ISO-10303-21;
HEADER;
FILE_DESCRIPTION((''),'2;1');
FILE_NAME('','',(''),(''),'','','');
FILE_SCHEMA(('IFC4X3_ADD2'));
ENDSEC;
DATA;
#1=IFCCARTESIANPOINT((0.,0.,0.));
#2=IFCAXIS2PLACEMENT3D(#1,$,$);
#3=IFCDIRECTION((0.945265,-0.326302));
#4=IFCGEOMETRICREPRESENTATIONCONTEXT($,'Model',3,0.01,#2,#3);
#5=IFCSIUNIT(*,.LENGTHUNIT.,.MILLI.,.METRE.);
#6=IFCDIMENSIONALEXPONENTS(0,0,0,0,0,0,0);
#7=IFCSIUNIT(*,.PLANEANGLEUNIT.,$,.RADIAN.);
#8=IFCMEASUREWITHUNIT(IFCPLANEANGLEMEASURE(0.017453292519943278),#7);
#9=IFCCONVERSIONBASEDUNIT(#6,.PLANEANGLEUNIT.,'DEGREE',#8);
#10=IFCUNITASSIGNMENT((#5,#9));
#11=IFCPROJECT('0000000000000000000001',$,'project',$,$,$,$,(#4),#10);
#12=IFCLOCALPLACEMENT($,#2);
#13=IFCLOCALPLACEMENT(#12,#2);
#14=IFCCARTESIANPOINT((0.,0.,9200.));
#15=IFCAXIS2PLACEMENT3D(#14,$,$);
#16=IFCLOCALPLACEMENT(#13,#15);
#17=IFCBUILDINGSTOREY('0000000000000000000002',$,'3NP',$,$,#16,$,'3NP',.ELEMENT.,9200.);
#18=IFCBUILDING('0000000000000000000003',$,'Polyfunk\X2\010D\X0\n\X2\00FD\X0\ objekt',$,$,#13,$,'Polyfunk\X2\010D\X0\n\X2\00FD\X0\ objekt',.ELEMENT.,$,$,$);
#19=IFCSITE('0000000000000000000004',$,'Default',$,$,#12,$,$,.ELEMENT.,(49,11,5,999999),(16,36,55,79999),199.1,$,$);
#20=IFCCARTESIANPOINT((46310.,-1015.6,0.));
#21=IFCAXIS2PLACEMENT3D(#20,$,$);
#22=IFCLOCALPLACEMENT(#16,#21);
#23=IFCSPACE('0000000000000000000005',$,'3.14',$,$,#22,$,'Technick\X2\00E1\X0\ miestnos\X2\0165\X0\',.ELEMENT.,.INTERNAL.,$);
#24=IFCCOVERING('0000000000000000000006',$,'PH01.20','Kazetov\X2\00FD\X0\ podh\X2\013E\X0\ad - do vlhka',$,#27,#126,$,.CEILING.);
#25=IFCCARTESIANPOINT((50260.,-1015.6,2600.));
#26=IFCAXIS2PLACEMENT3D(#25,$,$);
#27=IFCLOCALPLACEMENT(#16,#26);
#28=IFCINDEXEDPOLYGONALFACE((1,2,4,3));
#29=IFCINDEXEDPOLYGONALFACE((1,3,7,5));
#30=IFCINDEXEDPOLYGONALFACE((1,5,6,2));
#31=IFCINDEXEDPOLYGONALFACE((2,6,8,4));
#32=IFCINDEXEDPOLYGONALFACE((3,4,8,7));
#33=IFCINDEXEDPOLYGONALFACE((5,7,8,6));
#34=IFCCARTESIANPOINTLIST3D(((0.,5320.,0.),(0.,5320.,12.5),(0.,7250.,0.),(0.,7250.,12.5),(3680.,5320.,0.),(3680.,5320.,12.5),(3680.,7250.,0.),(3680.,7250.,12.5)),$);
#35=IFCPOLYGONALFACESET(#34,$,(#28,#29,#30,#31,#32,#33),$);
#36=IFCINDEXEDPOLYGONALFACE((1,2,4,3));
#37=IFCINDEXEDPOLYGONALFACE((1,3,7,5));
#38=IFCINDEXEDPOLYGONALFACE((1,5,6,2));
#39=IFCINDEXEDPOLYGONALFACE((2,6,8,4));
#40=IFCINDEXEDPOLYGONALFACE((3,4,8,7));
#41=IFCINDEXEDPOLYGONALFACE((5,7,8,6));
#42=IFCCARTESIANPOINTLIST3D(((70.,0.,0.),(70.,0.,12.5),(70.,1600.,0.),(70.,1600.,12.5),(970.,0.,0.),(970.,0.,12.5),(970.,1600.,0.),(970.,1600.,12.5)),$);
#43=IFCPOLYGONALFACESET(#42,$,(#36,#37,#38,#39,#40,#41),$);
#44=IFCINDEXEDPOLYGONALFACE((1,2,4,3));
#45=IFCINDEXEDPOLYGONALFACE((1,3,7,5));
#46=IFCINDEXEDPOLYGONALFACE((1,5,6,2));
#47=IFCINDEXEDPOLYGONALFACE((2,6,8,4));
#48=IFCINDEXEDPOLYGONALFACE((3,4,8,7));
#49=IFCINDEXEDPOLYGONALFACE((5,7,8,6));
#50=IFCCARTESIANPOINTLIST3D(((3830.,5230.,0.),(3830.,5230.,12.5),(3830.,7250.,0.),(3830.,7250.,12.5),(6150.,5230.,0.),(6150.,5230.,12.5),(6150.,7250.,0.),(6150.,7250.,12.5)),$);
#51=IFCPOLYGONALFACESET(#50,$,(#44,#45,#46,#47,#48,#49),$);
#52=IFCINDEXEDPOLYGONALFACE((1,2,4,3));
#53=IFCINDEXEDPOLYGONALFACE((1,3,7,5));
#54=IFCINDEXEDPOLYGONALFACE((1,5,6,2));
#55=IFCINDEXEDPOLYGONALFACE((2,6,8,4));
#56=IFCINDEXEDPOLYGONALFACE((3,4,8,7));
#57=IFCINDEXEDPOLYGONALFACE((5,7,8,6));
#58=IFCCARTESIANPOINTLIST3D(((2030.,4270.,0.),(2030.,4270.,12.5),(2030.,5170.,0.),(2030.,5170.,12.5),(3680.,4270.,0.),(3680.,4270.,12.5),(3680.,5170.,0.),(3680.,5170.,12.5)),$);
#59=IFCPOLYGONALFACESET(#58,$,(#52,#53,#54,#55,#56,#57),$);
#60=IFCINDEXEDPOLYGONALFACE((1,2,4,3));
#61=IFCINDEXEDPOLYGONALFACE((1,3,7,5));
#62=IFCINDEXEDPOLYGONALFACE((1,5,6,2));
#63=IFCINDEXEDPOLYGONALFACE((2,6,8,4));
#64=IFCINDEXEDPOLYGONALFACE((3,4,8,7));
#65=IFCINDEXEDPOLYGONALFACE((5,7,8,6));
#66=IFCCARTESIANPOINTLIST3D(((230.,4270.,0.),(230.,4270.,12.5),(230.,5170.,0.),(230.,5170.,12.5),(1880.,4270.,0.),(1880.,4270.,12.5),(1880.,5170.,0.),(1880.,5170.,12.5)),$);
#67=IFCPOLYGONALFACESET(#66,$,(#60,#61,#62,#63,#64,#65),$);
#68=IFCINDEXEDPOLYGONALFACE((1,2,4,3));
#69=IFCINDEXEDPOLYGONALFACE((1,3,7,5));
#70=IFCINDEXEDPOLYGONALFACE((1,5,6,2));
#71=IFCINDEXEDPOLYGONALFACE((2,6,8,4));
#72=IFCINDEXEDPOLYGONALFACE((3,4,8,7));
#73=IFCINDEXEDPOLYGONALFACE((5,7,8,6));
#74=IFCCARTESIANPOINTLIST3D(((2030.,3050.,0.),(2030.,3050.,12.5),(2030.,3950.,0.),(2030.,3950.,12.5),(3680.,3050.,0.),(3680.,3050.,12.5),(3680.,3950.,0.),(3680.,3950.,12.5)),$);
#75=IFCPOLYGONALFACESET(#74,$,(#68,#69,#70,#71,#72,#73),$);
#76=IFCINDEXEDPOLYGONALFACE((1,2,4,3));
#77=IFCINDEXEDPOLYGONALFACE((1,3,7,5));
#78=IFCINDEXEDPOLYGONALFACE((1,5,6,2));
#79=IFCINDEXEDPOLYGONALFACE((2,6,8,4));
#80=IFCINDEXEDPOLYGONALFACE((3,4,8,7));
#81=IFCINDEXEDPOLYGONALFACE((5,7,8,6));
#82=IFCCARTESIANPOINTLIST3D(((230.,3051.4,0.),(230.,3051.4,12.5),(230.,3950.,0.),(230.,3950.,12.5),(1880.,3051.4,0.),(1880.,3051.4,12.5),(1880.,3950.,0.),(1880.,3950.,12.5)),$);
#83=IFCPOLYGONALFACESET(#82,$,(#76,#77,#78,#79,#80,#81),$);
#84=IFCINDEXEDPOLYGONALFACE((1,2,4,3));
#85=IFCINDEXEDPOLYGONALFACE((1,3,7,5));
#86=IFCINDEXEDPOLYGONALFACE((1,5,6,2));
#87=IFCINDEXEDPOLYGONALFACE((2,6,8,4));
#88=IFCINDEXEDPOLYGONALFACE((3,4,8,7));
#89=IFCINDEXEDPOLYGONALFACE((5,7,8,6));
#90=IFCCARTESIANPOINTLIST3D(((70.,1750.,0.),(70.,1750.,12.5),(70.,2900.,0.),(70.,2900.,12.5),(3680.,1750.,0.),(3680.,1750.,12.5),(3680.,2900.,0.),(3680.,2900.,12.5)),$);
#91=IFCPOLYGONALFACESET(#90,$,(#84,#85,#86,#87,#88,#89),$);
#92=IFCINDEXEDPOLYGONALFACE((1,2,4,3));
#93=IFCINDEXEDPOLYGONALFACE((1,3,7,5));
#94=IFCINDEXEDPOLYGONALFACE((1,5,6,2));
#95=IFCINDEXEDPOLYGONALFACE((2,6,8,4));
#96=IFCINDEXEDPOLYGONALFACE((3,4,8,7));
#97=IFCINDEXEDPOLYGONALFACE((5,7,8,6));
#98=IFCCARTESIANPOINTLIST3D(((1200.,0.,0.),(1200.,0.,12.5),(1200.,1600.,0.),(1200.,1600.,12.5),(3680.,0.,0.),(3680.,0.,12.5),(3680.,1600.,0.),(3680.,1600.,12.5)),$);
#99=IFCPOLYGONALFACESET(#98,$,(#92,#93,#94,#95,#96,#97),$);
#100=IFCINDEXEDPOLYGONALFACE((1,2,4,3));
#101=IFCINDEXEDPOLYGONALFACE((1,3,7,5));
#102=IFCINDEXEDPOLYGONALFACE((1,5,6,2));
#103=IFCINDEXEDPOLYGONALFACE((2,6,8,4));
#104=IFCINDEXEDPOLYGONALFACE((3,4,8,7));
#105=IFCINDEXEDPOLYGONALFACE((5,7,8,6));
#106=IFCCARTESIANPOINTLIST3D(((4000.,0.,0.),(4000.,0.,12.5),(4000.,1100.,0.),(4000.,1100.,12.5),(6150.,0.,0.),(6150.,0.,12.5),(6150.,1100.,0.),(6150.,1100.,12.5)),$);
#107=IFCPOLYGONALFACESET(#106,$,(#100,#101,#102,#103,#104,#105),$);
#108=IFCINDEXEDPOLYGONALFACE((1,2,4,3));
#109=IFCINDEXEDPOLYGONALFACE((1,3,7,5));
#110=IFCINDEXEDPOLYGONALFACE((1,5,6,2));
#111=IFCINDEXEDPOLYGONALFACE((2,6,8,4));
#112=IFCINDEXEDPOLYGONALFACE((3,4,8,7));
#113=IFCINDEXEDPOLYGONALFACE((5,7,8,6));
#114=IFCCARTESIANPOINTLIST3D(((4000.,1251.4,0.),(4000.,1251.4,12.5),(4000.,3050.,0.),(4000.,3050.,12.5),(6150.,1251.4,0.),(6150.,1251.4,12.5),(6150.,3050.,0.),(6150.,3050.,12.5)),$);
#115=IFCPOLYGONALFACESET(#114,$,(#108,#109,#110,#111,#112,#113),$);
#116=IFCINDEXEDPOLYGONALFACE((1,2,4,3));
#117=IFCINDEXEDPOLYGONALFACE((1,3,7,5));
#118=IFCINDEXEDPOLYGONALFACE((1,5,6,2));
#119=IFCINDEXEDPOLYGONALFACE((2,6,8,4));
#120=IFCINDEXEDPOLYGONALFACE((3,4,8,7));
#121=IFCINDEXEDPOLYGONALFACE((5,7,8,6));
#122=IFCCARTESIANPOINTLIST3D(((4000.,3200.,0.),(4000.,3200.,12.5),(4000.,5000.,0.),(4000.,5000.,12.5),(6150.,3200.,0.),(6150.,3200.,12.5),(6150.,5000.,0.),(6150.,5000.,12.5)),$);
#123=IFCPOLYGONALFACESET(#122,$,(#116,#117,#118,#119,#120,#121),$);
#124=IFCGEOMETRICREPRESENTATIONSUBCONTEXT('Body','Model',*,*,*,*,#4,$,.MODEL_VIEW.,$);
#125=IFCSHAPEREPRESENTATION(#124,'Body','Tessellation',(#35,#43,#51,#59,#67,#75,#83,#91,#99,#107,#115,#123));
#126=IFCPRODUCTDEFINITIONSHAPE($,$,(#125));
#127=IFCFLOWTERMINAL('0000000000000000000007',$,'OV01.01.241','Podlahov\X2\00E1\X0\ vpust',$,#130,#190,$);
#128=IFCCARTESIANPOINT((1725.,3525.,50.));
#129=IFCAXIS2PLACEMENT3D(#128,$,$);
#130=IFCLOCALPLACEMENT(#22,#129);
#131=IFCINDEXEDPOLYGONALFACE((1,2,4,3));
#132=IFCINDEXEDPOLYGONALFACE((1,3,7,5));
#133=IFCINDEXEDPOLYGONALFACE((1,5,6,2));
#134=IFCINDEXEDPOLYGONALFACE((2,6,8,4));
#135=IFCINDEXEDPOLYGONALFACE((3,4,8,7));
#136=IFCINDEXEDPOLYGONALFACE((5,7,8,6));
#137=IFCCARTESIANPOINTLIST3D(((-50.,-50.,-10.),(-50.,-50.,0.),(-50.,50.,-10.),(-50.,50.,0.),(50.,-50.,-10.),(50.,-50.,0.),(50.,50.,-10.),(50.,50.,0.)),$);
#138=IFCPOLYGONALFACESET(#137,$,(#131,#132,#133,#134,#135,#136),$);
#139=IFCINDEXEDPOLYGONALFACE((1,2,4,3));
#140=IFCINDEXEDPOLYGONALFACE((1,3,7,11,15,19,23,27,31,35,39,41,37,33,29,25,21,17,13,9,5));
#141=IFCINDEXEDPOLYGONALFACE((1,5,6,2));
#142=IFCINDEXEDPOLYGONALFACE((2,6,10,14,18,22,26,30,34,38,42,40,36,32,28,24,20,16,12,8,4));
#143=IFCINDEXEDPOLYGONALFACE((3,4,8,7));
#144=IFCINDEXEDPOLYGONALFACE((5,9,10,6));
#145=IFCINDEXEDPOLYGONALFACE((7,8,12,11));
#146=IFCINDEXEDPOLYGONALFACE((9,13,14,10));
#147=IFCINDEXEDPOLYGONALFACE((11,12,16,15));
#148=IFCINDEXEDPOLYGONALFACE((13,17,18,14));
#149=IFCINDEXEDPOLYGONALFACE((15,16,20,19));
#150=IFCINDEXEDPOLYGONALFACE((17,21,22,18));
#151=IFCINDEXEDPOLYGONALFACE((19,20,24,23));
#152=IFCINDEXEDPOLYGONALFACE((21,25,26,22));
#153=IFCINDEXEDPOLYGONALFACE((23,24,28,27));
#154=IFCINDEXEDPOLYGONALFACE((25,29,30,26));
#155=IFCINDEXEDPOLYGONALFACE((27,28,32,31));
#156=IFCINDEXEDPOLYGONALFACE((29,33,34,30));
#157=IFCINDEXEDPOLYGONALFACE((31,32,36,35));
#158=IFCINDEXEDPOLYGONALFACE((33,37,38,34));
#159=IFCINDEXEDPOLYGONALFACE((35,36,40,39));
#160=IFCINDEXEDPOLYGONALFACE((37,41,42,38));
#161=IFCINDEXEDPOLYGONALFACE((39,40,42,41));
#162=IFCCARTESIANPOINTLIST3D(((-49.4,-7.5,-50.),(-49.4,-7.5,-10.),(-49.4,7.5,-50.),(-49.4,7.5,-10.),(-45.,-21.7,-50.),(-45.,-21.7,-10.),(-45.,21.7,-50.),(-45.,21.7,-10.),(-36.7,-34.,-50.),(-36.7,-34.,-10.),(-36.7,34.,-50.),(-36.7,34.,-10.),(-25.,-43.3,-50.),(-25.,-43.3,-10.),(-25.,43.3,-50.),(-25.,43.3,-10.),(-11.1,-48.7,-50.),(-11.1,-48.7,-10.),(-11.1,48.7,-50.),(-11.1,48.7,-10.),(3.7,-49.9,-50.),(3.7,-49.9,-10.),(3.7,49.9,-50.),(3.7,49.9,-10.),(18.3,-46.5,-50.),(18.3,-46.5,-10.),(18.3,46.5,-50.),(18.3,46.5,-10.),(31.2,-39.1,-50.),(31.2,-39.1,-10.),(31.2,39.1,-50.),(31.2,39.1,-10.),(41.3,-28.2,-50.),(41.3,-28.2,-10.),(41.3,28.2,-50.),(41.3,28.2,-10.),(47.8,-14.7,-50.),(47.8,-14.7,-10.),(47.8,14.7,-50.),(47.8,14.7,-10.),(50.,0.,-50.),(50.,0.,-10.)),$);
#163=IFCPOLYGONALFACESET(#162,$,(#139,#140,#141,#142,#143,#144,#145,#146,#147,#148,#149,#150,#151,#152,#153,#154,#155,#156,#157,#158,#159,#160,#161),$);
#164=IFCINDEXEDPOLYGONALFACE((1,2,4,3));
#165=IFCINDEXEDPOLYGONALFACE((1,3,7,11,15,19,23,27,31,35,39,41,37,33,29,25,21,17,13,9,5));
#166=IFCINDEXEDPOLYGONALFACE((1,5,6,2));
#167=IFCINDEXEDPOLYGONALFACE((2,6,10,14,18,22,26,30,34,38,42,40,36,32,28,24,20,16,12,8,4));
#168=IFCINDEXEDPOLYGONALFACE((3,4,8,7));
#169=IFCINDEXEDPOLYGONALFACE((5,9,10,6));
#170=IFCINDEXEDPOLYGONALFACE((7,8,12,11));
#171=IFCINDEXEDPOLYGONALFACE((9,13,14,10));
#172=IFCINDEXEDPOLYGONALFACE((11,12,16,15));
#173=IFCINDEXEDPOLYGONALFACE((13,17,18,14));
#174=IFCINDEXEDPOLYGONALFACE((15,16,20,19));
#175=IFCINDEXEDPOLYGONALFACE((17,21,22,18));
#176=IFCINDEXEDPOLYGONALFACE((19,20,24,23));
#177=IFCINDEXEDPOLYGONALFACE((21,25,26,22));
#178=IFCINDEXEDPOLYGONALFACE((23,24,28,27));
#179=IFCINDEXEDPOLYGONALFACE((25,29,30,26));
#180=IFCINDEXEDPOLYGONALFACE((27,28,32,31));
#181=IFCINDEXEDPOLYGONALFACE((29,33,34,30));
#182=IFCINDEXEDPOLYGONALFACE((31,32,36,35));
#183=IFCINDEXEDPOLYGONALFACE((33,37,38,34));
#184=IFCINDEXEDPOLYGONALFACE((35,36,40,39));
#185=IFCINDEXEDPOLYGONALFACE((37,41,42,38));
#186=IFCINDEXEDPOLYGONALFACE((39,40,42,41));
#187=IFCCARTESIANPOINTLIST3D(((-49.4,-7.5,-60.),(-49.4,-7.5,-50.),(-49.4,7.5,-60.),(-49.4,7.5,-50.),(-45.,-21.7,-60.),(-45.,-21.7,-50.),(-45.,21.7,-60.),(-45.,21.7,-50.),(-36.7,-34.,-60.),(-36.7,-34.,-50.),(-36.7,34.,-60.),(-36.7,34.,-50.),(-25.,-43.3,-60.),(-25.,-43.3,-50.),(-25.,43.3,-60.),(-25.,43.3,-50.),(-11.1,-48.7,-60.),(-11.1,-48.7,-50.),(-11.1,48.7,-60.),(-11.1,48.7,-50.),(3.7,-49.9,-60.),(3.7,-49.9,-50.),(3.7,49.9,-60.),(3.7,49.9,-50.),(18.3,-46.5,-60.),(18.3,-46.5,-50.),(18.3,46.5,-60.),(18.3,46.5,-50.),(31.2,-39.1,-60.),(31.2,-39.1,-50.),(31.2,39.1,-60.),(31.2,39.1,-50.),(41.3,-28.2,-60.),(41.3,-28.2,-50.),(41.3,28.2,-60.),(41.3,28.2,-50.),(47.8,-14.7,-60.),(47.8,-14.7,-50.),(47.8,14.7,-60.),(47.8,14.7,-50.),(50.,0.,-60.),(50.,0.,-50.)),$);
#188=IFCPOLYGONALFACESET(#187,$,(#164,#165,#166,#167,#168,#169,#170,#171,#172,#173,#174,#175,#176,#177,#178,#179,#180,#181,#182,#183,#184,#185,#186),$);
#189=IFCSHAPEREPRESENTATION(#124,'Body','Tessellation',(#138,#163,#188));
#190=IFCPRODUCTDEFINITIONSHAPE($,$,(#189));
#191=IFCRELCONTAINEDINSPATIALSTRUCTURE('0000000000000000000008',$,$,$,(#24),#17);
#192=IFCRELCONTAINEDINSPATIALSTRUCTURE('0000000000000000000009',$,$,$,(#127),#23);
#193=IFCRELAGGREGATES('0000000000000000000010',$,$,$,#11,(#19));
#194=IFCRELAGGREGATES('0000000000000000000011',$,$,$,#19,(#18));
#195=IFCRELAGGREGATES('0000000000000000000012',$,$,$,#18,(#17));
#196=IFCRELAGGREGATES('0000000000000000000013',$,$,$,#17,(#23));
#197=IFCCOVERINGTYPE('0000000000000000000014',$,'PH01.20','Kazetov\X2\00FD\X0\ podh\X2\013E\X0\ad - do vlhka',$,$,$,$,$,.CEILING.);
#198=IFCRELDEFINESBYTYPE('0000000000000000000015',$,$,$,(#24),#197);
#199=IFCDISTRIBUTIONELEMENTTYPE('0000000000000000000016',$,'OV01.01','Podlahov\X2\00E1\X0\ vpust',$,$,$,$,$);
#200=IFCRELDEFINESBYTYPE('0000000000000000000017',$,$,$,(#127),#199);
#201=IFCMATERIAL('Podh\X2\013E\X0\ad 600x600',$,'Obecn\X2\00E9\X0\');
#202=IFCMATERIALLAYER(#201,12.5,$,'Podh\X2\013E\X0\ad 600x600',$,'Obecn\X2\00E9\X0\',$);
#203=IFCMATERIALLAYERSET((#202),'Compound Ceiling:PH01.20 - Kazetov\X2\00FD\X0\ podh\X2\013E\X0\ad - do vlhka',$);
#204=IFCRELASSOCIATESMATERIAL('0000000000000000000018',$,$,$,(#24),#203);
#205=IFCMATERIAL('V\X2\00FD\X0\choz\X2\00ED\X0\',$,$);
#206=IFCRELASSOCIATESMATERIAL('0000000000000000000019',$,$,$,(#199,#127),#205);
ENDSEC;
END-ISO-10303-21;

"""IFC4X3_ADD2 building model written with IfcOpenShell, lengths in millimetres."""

from ifc_helpers import new_model, entity, si_unit, converted_unit, direction, frame, frame_2d, origin, origin_2d_with_axis, place, context, subcontext, project, spatial, rectangle, circle, extrude, source, transform, mapped, material, layer, layer_set, layer_usage, type_object, type_shapes, element, save


model = new_model("IFC4X3_ADD2")

# Units and contexts
model_context = context("Model", 3, precision=0.01, world=origin(), true_north=direction((0.945265, -0.326302)))
body_context = subcontext(model_context, "Body", "Model", "MODEL_VIEW")
ifc_project = project(units=[si_unit("LENGTHUNIT", "METRE", prefix="MILLI"), converted_unit("PLANEANGLEUNIT", "DEGREE", entity("IfcPlaneAngleMeasure", 0.017453292519943278), si_unit("PLANEANGLEUNIT", "RADIAN"), dimensions=[0, 0, 0, 0, 0, 0, 0])], contexts=[model_context])

# Site, building, storey
site_placement = place(None, origin())
site = spatial("IfcSite", under=ifc_project, at=site_placement, Name="Default", CompositionType="ELEMENT", RefLatitude=(49, 11, 5, 999999), RefLongitude=(16, 36, 55, 79999), RefElevation=199.1)
building_placement = place(site_placement, origin())
building = spatial("IfcBuilding", under=site, at=building_placement, Name="Polyfunkčný objekt", LongName="Polyfunkčný objekt", CompositionType="ELEMENT")
storey_placement = place(building_placement, frame((0.0, 0.0, 9200.0)))
storey = spatial("IfcBuildingStorey", under=building, at=storey_placement, Name="3NP", LongName="3NP", CompositionType="ELEMENT", Elevation=9200.0)

# Covering
ifc_material_1 = material(Name="Podhľad 600x600", Category="Obecné")
ifc_layer_1 = layer(ifc_material_1, 12.5, Name="Podhľad 600x600", Category="Obecné")
ifc_layer_set_1 = layer_set([ifc_layer_1], Name="Compound Ceiling:PH01.20 - Kazetový podhľad - do vlhka")
ifc_layer_usage_1 = layer_usage(ifc_layer_set_1, "AXIS3", "NEGATIVE", 0.0)
covering_type = type_object("IfcCoveringType", Name="PH01.20", Description="Kazetový podhľad - do vlhka", PredefinedType="CEILING")
covering_placement = place(storey_placement, frame((50260.0, -1015.6, 2600.0)))
element("IfcCovering", 1, at=covering_placement, inside=storey, type_object=covering_type, material=ifc_layer_usage_1, Name="PH01.20", Description="Kazetový podhľad - do vlhka", PredefinedType="CEILING", context=body_context, shape_type="SweptSolid", body=[
    extrude(rectangle(XDim=1930.0, YDim=3680.0, at=frame_2d((0.0, 0.0), x_axis=(1.0, 0.0))), frame((1840.0, 6285.0, 0.0), z_axis=(0.0, 0.0, 1.0), x_axis=(0.0, -1.0, 0.0)), (0.0, 0.0, 1.0), 12.5),
    extrude(rectangle(XDim=1600.0, YDim=900.0, at=origin_2d_with_axis()), frame((520.0, 800.0, 0.0), z_axis=(0.0, 0.0, 1.0), x_axis=(0.0, 1.0, 0.0)), (0.0, 0.0, 1.0), 12.5),
    extrude(rectangle(XDim=2320.0, YDim=2020.0, at=frame_2d((0.0, 0.0), x_axis=(1.0, 0.0))), frame((4990.0, 6240.0, 0.0), z_axis=(0.0, 0.0, 1.0), x_axis=(-1.0, 0.0, 0.0)), (0.0, 0.0, 1.0), 12.5),
    extrude(rectangle(XDim=900.0, YDim=1650.0, at=frame_2d((0.0, 0.0), x_axis=(1.0, 0.0))), frame((2855.0, 4720.0, 0.0), z_axis=(0.0, 0.0, 1.0), x_axis=(0.0, 1.0, 0.0)), (0.0, 0.0, 1.0), 12.5),
    extrude(rectangle(XDim=1650.0, YDim=900.0, at=frame_2d((0.0, 0.0), x_axis=(1.0, 0.0))), frame((1055.0, 4720.0, 0.0), z_axis=(0.0, 0.0, 1.0), x_axis=(-1.0, 0.0, 0.0)), (0.0, 0.0, 1.0), 12.5),
    extrude(rectangle(XDim=900.0, YDim=1650.0, at=frame_2d((0.0, 0.0), x_axis=(1.0, 0.0))), frame((2855.0, 3500.0, 0.0), z_axis=(0.0, 0.0, 1.0), x_axis=(0.0, -1.0, 0.0)), (0.0, 0.0, 1.0), 12.5),
    extrude(rectangle(XDim=1650.0, YDim=898.6, at=frame_2d((0.0, 0.0), x_axis=(1.0, 0.0))), frame((1055.0, 3500.7, 0.0), z_axis=(0.0, 0.0, 1.0), x_axis=(-1.0, 0.0, 0.0)), (0.0, 0.0, 1.0), 12.5),
    extrude(rectangle(XDim=3610.0, YDim=1150.0, at=frame_2d((0.0, 0.0), x_axis=(1.0, 0.0))), frame((1875.0, 2325.0, 0.0), z_axis=(0.0, 0.0, 1.0), x_axis=(-1.0, 0.0, 0.0)), (0.0, 0.0, 1.0), 12.5),
    extrude(rectangle(XDim=2480.0, YDim=1600.0, at=origin_2d_with_axis()), frame((2440.0, 800.0, 0.0), z_axis=(0.0, 0.0, 1.0), x_axis=(-1.0, 0.0, 0.0)), (0.0, 0.0, 1.0), 12.5),
    extrude(rectangle(XDim=1100.0, YDim=2150.0, at=frame_2d((0.0, 0.0), x_axis=(1.0, 0.0))), frame((5075.0, 550.0, 0.0), z_axis=(0.0, 0.0, 1.0), x_axis=(0.0, 1.0, 0.0)), (0.0, 0.0, 1.0), 12.5),
    extrude(rectangle(XDim=1798.6, YDim=2150.0, at=origin_2d_with_axis()), frame((5075.0, 2150.7, 0.0), z_axis=(0.0, 0.0, 1.0), x_axis=(0.0, 1.0, 0.0)), (0.0, 0.0, 1.0), 12.5),
    extrude(rectangle(XDim=1800.0, YDim=2150.0, at=frame_2d((0.0, 0.0), x_axis=(1.0, 0.0))), frame((5075.0, 4100.0, 0.0), z_axis=(0.0, 0.0, 1.0), x_axis=(0.0, 1.0, 0.0)), (0.0, 0.0, 1.0), 12.5),
])

# Shared definitions
space_placement = place(storey_placement, frame((46310.0, -1015.6, 0.0)))
space = spatial("IfcSpace", under=storey, at=space_placement, Name="3.14", LongName="Technická miestnosť", CompositionType="ELEMENT", PredefinedType="INTERNAL")

# Flow terminal
ifc_material_2 = material(Name="Výchozí")
distribution_element_type = type_object("IfcDistributionElementType", Name="OV01.01", Description="Podlahová vpust", material=ifc_material_2)
shared_shape_1 = source(origin(), body_context, "Body", "SweptSolid", [
    extrude(rectangle(XDim=100.0, YDim=100.0, at=frame_2d((0.0, 0.0), x_axis=(1.0, 0.0))), frame((0.0, 0.0, -10.0), z_axis=(0.0, 0.0, 1.0), x_axis=(-1.0, 0.0, 0.0)), (0.0, 0.0, 1.0), 10.0),
    extrude(circle(Radius=50.0, at=frame_2d((0.0, 0.0), x_axis=(1.0, 0.0))), frame((0.0, 0.0, -50.0)), (0.0, 0.0, 1.0), 40.0),
    extrude(circle(Radius=50.0, at=frame_2d((0.0, 0.0), x_axis=(1.0, 0.0))), frame((0.0, 0.0, -60.0)), (0.0, 0.0, 1.0), 10.0),
])
type_shapes(distribution_element_type, [shared_shape_1])
flow_terminal_placement = place(space_placement, frame((1725.0, 3525.0, 50.0)))
element("IfcFlowTerminal", 2, at=flow_terminal_placement, inside=space, type_object=distribution_element_type, material=ifc_material_2, Name="OV01.01.241", Description="Podlahová vpust", context=body_context, shape_type="MappedRepresentation", body=[
    mapped(shared_shape_1, transform((0.0, 0.0, 0.0), scale=1.0)),
])

save(model, "model.ifc")
